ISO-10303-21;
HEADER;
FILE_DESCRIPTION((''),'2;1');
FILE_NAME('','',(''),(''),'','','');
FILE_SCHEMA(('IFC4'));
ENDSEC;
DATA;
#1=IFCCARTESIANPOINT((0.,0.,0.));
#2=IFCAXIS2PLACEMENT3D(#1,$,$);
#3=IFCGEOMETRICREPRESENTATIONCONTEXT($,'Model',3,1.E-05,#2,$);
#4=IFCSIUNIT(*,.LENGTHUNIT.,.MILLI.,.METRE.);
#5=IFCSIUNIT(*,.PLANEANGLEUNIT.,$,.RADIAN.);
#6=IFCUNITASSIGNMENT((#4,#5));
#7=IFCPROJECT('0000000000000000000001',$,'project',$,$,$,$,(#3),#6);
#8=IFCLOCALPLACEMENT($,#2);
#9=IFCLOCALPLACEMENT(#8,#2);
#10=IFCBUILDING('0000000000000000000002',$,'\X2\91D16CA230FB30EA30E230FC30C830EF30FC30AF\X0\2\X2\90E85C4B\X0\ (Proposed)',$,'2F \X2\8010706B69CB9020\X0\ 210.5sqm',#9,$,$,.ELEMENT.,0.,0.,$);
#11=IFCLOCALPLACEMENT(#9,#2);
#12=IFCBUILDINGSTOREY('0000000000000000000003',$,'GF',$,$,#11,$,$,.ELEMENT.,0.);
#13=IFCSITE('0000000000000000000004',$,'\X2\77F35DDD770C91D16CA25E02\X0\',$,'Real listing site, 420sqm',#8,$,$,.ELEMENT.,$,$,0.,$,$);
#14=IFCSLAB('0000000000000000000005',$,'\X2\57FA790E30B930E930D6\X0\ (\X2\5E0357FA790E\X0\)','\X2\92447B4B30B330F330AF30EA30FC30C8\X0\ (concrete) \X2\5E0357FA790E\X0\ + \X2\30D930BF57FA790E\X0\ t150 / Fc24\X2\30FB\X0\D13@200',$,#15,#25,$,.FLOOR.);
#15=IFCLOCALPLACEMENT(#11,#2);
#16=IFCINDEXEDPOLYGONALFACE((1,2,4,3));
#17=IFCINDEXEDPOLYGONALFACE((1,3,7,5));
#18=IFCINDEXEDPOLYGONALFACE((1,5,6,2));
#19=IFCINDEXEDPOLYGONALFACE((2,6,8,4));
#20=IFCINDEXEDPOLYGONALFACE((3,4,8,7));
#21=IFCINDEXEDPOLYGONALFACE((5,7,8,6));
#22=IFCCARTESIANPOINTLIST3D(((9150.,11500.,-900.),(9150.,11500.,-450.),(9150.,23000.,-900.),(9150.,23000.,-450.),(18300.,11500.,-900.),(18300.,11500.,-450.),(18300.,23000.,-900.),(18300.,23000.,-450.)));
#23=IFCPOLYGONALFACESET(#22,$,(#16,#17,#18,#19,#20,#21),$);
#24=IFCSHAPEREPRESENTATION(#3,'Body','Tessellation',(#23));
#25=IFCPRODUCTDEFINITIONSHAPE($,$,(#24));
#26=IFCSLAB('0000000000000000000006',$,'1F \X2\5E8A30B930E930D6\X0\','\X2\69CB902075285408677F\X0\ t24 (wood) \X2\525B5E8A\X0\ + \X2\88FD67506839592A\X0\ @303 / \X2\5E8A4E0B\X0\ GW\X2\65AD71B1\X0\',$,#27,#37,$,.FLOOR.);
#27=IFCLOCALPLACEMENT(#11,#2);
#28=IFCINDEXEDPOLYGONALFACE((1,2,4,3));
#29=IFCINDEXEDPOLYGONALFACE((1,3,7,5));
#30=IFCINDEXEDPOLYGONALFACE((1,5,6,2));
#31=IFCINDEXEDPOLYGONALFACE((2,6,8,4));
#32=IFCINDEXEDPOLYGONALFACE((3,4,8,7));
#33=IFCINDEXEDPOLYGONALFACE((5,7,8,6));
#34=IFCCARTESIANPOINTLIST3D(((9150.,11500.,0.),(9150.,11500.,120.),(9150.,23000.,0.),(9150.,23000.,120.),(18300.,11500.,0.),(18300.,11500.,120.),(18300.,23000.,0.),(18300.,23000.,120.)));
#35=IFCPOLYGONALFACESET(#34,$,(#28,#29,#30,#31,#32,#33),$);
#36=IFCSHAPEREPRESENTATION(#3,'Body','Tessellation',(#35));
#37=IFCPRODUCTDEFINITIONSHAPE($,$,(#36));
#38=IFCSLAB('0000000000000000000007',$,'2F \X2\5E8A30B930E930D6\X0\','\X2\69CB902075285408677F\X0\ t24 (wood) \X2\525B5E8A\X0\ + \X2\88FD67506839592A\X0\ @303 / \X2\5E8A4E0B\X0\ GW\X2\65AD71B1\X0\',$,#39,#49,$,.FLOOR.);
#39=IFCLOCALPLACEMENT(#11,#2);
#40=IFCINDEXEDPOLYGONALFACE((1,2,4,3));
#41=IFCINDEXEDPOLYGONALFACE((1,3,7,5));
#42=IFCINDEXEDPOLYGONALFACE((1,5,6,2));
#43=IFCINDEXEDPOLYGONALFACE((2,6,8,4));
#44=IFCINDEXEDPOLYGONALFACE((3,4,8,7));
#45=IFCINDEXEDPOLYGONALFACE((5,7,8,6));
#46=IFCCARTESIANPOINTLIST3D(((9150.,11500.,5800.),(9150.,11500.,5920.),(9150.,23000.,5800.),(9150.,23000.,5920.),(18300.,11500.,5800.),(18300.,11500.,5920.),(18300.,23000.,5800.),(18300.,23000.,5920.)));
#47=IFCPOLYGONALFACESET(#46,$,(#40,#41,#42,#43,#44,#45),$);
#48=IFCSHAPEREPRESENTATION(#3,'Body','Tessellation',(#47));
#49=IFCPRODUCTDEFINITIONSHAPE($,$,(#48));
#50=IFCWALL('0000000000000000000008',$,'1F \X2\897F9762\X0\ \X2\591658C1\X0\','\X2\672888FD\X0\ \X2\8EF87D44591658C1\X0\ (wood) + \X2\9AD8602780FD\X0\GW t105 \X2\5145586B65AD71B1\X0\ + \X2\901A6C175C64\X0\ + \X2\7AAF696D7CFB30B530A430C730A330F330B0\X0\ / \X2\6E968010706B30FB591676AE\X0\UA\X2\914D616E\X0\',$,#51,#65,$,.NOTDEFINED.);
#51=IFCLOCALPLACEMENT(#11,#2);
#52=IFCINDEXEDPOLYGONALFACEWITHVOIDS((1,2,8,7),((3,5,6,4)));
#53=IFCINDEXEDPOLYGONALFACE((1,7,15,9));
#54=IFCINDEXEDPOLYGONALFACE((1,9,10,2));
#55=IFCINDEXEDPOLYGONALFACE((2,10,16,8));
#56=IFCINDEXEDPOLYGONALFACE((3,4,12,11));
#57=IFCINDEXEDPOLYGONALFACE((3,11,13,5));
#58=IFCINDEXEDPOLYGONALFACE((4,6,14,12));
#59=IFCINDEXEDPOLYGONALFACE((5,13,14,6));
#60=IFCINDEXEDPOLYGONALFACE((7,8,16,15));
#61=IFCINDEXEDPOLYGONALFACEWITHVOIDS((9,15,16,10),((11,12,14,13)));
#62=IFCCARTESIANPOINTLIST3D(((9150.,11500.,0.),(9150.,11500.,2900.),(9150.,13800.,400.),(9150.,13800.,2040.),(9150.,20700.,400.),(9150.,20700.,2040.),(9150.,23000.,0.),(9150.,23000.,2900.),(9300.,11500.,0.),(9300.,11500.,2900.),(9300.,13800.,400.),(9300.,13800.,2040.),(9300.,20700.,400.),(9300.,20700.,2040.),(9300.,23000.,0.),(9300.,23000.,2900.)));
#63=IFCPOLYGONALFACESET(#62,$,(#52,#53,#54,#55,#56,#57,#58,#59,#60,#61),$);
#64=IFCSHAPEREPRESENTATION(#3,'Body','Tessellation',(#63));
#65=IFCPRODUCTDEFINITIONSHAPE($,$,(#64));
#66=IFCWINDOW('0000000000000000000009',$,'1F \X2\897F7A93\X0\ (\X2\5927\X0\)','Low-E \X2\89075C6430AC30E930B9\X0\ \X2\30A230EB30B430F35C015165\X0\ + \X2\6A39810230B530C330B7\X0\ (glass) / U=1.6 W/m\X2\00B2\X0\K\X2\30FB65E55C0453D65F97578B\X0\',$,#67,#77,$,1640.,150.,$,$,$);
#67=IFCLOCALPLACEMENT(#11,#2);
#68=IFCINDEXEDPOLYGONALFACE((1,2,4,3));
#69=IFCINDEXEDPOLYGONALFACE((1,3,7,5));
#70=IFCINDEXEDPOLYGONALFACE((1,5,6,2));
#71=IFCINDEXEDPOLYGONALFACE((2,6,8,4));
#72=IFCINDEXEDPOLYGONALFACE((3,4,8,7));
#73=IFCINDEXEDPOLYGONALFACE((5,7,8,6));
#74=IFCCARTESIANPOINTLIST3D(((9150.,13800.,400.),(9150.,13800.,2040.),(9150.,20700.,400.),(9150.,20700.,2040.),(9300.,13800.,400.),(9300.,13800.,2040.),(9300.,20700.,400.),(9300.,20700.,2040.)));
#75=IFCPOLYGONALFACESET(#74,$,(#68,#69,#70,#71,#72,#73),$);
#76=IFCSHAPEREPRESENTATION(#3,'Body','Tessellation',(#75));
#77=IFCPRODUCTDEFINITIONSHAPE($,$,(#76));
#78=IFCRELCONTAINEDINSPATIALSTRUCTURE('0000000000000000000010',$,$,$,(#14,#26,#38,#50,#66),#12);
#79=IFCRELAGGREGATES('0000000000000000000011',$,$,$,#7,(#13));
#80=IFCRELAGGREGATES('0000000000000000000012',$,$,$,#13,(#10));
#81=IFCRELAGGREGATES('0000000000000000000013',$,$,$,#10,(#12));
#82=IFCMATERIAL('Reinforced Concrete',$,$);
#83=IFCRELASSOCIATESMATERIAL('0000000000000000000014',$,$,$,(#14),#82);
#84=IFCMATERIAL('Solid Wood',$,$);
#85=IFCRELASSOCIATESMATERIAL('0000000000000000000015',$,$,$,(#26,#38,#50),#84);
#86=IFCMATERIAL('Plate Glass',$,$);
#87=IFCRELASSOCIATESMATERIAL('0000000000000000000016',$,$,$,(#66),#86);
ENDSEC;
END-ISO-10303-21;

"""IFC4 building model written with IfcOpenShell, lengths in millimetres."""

from ifc_helpers import new_model, si_unit, frame, frame_2d, origin, place, context, project, spatial, rectangle, extrude, material, element, fill, save


model = new_model("IFC4")

# Units and contexts
model_context = context("Model", 3, precision=1e-05, world=origin())
ifc_project = project(units=[si_unit("LENGTHUNIT", "METRE", prefix="MILLI"), si_unit("PLANEANGLEUNIT", "RADIAN")], contexts=[model_context])

# Site, building, storey
site_placement = place(None, origin())
site = spatial("IfcSite", under=ifc_project, at=site_placement, Name="石川県金沢市", ObjectType="Real listing site, 420sqm", CompositionType="ELEMENT", RefElevation=0.0)
building_placement = place(site_placement, origin())
building = spatial("IfcBuilding", under=site, at=building_placement, Name="金沢・リモートワーク2部屋 (Proposed)", ObjectType="2F 耐火構造 210.5sqm", CompositionType="ELEMENT", ElevationOfRefHeight=0.0, ElevationOfTerrain=0.0)
storey_placement = place(building_placement, origin())
storey = spatial("IfcBuildingStorey", under=building, at=storey_placement, Name="GF", CompositionType="ELEMENT", Elevation=0.0)

# Shared definitions
ifc_material_1 = material(Name="Solid Wood")

# Slabs
ifc_material_2 = material(Name="Reinforced Concrete")
slab_1_placement = place(storey_placement, frame((4575.0, 5750.0, -450.0)))
element("IfcSlab", 1, at=slab_1_placement, inside=storey, material=ifc_material_2, Name="基礎スラブ (布基礎)", Description="鉄筋コンクリート (concrete) 布基礎 + ベタ基礎 t150 / Fc24・D13@200", PredefinedType="FLOOR", context=model_context, shape_type="SweptSolid", body=[
    extrude(rectangle(XDim=9150.0, YDim=11500.0, at=frame_2d((4575.0, 5750.0))), frame((4575.0, 5750.0, -450.0)), (0.0, 0.0, 1.0), 450.0),
])
slab_2_placement = place(storey_placement, frame((4575.0, 5750.0, 0.0)))
element("IfcSlab", 2, at=slab_2_placement, inside=storey, material=ifc_material_1, Name="1F 床スラブ", Description="構造用合板 t24 (wood) 剛床 + 製材根太 @303 / 床下 GW断熱", PredefinedType="FLOOR", context=model_context, shape_type="SweptSolid", body=[
    extrude(rectangle(XDim=9150.0, YDim=11500.0, at=frame_2d((4575.0, 5750.0))), frame((4575.0, 5750.0, 0.0)), (0.0, 0.0, 1.0), 120.0),
])
slab_3_placement = place(storey_placement, frame((4575.0, 5750.0, 2900.0)))
element("IfcSlab", 3, at=slab_3_placement, inside=storey, material=ifc_material_1, Name="2F 床スラブ", Description="構造用合板 t24 (wood) 剛床 + 製材根太 @303 / 床下 GW断熱", PredefinedType="FLOOR", context=model_context, shape_type="SweptSolid", body=[
    extrude(rectangle(XDim=9150.0, YDim=11500.0, at=frame_2d((4575.0, 5750.0))), frame((4575.0, 5750.0, 2900.0)), (0.0, 0.0, 1.0), 120.0),
])

# Shared definitions
ifc_material_3 = material(Name="Plate Glass")

# Wall, opening, window
wall_1_placement = place(storey_placement, frame((4575.0, 5750.0, 0.0)))
wall_1 = element("IfcWall", 4, at=wall_1_placement, inside=storey, material=ifc_material_1, Name="1F 西面 外壁", Description="木製 軸組外壁 (wood) + 高性能GW t105 充填断熱 + 通気層 + 窯業系サイディング / 準耐火・外皮UA配慮", PredefinedType="NOTDEFINED", context=model_context, shape_type="SweptSolid", body=[
    extrude(rectangle(XDim=150.0, YDim=11500.0, at=frame_2d((75.0, 5750.0))), frame((4575.0, 5750.0, 0.0)), (0.0, 0.0, 1.0), 2900.0),
])
opening_1_placement = place(storey_placement, frame((4575.0, 6900.0, 200.0)))
opening_1 = element("IfcOpeningElement", 5, at=opening_1_placement, cuts=wall_1, PredefinedType="NOTDEFINED", context=model_context, shape_type="SweptSolid", body=[
    extrude(rectangle(XDim=150.0, YDim=6900.0, at=frame_2d((75.0, 3450.0))), frame((4575.0, 6900.0, 200.0)), (0.0, 0.0, 1.0), 1640.0),
])
window_1_placement = place(storey_placement, frame((4575.0, 6900.0, 200.0)))
window_1 = element("IfcWindow", 6, at=window_1_placement, inside=storey, material=ifc_material_3, Name="1F 西窓 (大)", Description="Low-E 複層ガラス アルゴン封入 + 樹脂サッシ (glass) / U=1.6 W/m²K・日射取得型", OverallHeight=1640.0, OverallWidth=150.0, context=model_context, shape_type="SweptSolid", body=[
    extrude(rectangle(XDim=150.0, YDim=6900.0, at=frame_2d((75.0, 3450.0))), frame((4575.0, 6900.0, 200.0)), (0.0, 0.0, 1.0), 1640.0),
])
fill(opening_1, window_1)

save(model, "model.ifc")
